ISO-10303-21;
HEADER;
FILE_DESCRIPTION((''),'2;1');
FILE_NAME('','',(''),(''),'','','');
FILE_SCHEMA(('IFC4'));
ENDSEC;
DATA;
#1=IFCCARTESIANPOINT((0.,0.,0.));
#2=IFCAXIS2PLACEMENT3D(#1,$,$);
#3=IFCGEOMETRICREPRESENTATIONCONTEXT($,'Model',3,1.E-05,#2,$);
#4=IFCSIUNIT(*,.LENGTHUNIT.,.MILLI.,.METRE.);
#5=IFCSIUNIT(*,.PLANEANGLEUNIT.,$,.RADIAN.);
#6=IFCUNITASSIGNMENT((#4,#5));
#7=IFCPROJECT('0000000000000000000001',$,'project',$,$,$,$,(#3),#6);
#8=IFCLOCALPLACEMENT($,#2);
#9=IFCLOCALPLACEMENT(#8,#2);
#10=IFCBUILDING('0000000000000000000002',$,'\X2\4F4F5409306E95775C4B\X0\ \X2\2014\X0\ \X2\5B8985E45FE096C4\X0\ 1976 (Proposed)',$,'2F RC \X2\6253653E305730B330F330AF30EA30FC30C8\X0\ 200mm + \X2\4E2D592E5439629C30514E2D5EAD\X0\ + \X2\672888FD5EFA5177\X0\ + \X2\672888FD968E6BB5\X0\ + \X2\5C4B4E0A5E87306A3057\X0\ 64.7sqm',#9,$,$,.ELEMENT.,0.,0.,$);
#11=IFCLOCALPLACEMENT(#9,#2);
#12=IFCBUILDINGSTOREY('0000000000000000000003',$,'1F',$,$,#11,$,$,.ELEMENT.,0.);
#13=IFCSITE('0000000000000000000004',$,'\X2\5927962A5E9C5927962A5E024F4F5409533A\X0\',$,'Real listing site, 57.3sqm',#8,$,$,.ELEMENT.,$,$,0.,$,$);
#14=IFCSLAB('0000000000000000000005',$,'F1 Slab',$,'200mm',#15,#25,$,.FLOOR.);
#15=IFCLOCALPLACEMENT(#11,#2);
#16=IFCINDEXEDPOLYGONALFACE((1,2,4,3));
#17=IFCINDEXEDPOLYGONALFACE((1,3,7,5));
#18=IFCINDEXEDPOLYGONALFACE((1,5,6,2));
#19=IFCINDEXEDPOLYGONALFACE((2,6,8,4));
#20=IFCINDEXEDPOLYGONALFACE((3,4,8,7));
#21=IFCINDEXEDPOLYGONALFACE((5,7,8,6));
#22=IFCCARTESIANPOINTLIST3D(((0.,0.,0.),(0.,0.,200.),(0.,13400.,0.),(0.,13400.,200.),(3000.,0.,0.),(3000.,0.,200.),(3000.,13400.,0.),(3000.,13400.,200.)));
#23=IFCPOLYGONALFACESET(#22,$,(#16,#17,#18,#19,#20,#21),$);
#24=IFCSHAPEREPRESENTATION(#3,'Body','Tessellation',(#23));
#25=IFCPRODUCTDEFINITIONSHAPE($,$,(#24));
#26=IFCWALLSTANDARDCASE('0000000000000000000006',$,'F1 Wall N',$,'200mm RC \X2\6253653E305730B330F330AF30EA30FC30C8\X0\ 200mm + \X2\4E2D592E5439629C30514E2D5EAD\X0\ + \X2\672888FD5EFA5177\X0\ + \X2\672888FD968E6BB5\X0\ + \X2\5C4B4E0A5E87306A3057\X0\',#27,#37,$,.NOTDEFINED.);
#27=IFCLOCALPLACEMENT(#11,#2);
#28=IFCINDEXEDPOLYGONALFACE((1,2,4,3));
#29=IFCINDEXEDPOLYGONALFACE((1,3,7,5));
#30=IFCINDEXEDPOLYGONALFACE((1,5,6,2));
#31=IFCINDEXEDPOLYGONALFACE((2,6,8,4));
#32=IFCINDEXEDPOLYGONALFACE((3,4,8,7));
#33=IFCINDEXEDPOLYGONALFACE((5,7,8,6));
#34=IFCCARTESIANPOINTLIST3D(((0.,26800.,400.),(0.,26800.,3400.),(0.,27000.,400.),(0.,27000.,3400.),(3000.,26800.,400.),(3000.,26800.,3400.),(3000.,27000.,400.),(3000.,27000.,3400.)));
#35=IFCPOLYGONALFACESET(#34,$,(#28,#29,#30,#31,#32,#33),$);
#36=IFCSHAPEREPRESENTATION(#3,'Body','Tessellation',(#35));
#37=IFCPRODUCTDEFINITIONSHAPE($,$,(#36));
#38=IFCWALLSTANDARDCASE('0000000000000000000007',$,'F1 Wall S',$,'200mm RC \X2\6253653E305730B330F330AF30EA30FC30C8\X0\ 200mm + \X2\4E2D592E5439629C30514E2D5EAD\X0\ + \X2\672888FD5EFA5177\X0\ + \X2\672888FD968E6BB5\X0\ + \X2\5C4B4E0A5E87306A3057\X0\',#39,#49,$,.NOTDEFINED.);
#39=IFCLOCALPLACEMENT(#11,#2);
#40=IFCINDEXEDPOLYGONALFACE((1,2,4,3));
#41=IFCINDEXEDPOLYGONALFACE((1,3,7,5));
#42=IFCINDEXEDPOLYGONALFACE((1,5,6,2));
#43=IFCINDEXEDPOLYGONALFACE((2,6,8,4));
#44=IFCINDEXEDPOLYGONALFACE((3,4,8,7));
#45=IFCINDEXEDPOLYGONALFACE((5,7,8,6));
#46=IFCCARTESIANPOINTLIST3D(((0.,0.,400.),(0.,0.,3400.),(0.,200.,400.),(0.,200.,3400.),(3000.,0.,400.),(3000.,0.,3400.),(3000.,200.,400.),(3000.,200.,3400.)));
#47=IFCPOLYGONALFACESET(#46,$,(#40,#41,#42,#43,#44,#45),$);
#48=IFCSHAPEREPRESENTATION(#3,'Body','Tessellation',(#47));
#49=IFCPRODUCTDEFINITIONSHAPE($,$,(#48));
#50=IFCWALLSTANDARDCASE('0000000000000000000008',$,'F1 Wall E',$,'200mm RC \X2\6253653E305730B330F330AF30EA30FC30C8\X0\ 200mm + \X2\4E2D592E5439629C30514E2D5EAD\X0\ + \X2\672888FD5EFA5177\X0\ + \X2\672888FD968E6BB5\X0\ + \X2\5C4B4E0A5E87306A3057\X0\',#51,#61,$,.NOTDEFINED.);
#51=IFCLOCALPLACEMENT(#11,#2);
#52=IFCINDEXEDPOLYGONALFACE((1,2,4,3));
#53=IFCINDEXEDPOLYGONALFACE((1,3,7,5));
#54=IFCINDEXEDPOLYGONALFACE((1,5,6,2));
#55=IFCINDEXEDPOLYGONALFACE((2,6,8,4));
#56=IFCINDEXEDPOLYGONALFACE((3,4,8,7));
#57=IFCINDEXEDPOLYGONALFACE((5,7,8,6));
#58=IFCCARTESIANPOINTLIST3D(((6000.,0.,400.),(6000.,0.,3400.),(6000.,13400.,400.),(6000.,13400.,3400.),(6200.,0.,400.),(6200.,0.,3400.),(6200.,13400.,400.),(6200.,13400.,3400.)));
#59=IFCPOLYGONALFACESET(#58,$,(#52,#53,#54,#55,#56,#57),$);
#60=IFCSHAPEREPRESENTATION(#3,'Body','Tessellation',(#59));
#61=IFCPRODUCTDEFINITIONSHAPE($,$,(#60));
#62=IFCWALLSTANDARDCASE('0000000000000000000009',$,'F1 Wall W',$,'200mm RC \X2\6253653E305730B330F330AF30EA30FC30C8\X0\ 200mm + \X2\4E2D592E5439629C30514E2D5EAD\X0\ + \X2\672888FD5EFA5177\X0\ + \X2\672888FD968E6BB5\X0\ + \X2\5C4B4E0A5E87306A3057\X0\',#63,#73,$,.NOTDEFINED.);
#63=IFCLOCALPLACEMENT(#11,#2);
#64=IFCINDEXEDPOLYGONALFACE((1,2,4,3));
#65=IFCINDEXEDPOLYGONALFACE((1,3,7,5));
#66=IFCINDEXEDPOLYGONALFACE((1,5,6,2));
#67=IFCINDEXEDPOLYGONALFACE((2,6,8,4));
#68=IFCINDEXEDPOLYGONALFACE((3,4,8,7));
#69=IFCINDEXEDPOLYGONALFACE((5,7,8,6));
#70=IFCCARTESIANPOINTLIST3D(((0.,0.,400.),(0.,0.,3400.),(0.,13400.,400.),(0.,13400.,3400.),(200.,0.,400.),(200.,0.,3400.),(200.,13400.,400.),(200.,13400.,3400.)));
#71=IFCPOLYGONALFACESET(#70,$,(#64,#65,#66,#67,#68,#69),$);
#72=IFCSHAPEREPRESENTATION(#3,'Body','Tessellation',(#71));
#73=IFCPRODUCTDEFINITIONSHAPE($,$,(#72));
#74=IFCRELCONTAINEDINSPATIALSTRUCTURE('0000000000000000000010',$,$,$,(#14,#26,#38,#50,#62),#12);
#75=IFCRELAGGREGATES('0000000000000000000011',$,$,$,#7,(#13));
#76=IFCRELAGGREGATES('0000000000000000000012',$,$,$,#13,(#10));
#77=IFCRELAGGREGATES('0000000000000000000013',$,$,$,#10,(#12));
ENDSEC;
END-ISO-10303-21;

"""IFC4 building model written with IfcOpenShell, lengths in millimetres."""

from ifc_helpers import new_model, si_unit, frame, frame_2d, origin, place, context, project, spatial, rectangle, extrude, element, save


model = new_model("IFC4")

# Units and contexts
model_context = context("Model", 3, precision=1e-05, world=origin())
ifc_project = project(units=[si_unit("LENGTHUNIT", "METRE", prefix="MILLI"), si_unit("PLANEANGLEUNIT", "RADIAN")], contexts=[model_context])

# Site, building, storey
site_placement = place(None, origin())
site = spatial("IfcSite", under=ifc_project, at=site_placement, Name="大阪府大阪市住吉区", ObjectType="Real listing site, 57.3sqm", CompositionType="ELEMENT", RefElevation=0.0)
building_placement = place(site_placement, origin())
building = spatial("IfcBuilding", under=site, at=building_placement, Name="住吉の長屋 — 安藤忠雄 1976 (Proposed)", ObjectType="2F RC 打放しコンクリート 200mm + 中央吹抜け中庭 + 木製建具 + 木製階段 + 屋上庇なし 64.7sqm", CompositionType="ELEMENT", ElevationOfRefHeight=0.0, ElevationOfTerrain=0.0)
storey_placement = place(building_placement, origin())
storey = spatial("IfcBuildingStorey", under=building, at=storey_placement, Name="1F", CompositionType="ELEMENT", Elevation=0.0)

# Slab
slab_placement = place(storey_placement, origin())
element("IfcSlab", 1, at=slab_placement, inside=storey, Name="F1 Slab", ObjectType="200mm", PredefinedType="FLOOR", context=model_context, shape_type="SweptSolid", body=[
    extrude(rectangle(XDim=3000.0, YDim=13400.0, at=frame_2d((1500.0, 6700.0))), origin(), (0.0, 0.0, 1.0), 200.0),
])

# Walls
wall_1_placement = place(storey_placement, frame((0.0, 13400.0, 200.0)))
element("IfcWallStandardCase", 2, at=wall_1_placement, inside=storey, Name="F1 Wall N", ObjectType="200mm RC 打放しコンクリート 200mm + 中央吹抜け中庭 + 木製建具 + 木製階段 + 屋上庇なし", PredefinedType="NOTDEFINED", context=model_context, shape_type="SweptSolid", body=[
    extrude(rectangle(XDim=3000.0, YDim=200.0, at=frame_2d((1500.0, 100.0))), frame((0.0, 13400.0, 200.0)), (0.0, 0.0, 1.0), 3000.0),
])
wall_2_placement = place(storey_placement, frame((0.0, 0.0, 200.0)))
element("IfcWallStandardCase", 3, at=wall_2_placement, inside=storey, Name="F1 Wall S", ObjectType="200mm RC 打放しコンクリート 200mm + 中央吹抜け中庭 + 木製建具 + 木製階段 + 屋上庇なし", PredefinedType="NOTDEFINED", context=model_context, shape_type="SweptSolid", body=[
    extrude(rectangle(XDim=3000.0, YDim=200.0, at=frame_2d((1500.0, 100.0))), frame((0.0, 0.0, 200.0)), (0.0, 0.0, 1.0), 3000.0),
])
wall_3_placement = place(storey_placement, frame((3000.0, 0.0, 200.0)))
element("IfcWallStandardCase", 4, at=wall_3_placement, inside=storey, Name="F1 Wall E", ObjectType="200mm RC 打放しコンクリート 200mm + 中央吹抜け中庭 + 木製建具 + 木製階段 + 屋上庇なし", PredefinedType="NOTDEFINED", context=model_context, shape_type="SweptSolid", body=[
    extrude(rectangle(XDim=200.0, YDim=13400.0, at=frame_2d((100.0, 6700.0))), frame((3000.0, 0.0, 200.0)), (0.0, 0.0, 1.0), 3000.0),
])
wall_4_placement = place(storey_placement, frame((0.0, 0.0, 200.0)))
element("IfcWallStandardCase", 5, at=wall_4_placement, inside=storey, Name="F1 Wall W", ObjectType="200mm RC 打放しコンクリート 200mm + 中央吹抜け中庭 + 木製建具 + 木製階段 + 屋上庇なし", PredefinedType="NOTDEFINED", context=model_context, shape_type="SweptSolid", body=[
    extrude(rectangle(XDim=200.0, YDim=13400.0, at=frame_2d((100.0, 6700.0))), frame((0.0, 0.0, 200.0)), (0.0, 0.0, 1.0), 3000.0),
])

save(model, "model.ifc")
